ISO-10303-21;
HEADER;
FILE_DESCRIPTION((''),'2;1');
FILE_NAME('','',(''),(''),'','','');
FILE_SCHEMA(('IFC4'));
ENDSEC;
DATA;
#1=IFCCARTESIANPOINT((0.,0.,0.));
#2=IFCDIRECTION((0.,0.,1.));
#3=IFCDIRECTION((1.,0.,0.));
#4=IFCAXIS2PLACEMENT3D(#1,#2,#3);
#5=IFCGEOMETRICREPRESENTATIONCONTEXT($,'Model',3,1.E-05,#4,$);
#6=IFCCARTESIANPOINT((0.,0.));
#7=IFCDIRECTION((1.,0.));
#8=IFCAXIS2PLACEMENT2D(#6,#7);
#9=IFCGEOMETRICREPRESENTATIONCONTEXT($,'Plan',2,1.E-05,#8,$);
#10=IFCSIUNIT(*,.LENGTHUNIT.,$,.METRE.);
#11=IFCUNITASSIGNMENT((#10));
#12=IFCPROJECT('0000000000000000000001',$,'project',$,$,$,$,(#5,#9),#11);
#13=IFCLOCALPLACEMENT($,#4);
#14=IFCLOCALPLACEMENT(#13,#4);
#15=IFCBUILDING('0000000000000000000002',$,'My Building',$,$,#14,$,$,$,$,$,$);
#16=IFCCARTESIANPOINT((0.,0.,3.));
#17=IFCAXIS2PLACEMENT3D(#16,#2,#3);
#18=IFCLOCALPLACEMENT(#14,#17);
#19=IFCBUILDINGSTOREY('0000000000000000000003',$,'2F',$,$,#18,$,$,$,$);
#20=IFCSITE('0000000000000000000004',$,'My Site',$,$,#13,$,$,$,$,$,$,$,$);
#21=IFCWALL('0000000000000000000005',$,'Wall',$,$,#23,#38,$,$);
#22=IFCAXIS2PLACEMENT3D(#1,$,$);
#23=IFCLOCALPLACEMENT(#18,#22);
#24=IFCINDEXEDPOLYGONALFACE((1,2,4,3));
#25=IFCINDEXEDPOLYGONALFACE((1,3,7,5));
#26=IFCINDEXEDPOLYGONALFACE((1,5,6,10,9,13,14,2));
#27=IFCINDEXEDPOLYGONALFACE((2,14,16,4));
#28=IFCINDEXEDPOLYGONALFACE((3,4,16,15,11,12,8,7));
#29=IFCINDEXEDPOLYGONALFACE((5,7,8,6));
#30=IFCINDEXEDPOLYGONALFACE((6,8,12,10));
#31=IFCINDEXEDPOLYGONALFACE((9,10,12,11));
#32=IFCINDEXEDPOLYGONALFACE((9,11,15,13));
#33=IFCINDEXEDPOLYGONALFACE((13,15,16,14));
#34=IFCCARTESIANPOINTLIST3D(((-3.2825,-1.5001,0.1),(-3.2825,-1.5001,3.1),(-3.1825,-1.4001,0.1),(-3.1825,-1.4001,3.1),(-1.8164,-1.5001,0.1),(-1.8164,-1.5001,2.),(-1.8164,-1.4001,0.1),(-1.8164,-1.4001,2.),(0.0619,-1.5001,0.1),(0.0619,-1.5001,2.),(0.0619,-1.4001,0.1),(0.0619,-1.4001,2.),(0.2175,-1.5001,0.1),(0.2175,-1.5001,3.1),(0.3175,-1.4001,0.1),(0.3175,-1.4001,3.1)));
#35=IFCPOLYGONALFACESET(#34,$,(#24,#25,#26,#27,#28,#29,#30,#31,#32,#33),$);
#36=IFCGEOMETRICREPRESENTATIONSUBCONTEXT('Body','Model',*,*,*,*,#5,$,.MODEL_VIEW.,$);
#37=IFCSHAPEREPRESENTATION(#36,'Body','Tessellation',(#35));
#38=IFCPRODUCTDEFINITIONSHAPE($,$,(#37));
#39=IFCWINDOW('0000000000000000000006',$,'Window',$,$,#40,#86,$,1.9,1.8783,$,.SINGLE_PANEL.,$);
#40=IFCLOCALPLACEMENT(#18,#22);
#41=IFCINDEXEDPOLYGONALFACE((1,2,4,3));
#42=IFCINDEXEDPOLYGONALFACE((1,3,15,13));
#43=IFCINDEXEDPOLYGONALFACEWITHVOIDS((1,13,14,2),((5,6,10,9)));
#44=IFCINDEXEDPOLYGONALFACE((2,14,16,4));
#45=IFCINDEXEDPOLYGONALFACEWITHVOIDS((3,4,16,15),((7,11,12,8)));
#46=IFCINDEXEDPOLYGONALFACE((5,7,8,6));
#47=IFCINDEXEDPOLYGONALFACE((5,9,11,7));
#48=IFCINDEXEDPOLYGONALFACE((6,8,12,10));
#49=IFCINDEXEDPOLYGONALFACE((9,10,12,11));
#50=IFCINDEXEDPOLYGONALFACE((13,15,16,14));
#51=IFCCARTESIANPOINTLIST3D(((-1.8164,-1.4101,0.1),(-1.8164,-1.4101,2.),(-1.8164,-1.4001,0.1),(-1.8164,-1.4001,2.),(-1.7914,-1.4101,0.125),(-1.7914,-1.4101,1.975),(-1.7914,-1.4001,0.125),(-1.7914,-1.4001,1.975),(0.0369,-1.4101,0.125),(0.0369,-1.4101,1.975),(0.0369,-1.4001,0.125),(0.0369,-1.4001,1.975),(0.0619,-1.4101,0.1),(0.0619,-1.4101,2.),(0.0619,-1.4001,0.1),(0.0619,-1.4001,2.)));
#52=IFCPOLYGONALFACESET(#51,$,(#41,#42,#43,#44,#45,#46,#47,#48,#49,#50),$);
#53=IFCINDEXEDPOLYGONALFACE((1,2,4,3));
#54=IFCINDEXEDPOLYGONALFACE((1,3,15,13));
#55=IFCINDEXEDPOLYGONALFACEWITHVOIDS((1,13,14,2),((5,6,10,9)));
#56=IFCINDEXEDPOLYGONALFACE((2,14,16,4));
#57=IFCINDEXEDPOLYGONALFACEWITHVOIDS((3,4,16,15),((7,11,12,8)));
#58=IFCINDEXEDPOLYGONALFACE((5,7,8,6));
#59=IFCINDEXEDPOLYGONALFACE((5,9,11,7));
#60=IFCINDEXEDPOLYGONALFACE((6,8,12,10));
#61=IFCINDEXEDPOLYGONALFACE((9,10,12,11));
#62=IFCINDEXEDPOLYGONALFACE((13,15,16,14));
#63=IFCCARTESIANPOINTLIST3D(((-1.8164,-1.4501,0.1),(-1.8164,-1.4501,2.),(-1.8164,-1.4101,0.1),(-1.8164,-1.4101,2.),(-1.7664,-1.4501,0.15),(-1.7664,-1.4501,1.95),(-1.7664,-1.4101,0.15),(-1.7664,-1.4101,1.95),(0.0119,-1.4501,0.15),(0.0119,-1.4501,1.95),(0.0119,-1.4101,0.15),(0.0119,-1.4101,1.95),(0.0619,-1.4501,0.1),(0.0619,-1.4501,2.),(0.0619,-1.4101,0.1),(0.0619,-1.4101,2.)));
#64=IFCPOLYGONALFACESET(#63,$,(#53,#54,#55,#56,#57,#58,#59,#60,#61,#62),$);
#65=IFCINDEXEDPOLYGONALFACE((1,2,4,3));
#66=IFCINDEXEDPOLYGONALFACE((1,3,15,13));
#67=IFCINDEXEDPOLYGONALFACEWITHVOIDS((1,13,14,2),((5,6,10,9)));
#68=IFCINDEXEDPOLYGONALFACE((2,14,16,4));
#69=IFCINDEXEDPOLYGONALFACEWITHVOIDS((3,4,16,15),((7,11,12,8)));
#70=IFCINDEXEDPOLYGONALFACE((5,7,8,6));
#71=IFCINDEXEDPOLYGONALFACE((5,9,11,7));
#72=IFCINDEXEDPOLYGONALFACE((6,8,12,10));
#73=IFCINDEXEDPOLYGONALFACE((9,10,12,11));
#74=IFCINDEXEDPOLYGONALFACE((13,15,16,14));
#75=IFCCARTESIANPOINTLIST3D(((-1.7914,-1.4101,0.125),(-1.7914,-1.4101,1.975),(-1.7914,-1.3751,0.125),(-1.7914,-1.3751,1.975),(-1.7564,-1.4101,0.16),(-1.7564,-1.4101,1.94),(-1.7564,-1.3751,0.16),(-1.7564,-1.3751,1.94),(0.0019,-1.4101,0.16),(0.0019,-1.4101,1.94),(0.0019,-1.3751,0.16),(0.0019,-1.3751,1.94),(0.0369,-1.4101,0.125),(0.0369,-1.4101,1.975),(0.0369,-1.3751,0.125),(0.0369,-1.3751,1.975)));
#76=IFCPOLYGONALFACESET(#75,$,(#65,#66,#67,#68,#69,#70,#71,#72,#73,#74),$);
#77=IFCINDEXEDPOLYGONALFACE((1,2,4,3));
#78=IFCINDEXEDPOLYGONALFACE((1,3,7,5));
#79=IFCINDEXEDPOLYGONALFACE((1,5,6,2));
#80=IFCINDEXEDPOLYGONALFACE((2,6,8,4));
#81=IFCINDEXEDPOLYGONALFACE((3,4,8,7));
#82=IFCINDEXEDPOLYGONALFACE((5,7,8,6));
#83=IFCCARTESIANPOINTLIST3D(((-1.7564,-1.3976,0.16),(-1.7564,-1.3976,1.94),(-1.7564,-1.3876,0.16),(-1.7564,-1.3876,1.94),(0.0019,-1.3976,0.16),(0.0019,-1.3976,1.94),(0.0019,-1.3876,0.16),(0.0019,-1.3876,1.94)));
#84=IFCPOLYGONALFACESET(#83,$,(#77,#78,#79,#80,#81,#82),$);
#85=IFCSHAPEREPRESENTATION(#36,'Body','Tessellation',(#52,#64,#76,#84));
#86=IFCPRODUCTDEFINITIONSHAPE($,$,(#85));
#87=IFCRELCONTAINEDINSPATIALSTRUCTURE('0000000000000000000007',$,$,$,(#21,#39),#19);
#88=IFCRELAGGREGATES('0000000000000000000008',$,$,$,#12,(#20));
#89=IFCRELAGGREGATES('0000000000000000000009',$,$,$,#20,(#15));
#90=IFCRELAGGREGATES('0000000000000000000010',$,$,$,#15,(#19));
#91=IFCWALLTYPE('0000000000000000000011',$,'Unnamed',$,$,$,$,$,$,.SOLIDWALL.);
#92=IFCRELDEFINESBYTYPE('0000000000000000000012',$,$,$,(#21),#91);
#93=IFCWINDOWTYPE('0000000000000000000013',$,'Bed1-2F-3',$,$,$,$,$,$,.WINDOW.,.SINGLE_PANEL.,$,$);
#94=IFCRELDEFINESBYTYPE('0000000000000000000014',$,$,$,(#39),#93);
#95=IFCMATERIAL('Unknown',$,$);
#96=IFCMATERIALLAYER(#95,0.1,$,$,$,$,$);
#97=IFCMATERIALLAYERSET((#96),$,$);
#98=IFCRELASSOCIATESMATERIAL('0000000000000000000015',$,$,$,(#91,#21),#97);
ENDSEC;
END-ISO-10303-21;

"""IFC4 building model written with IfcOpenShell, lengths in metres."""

from ifc_helpers import new_model, entity, si_unit, frame, origin_with_axes, origin_2d_with_axis, place, context, subcontext, project, spatial, line, indexed_curve, outline, extrude, shape, source, transform, mapped, material, layer, layer_set, layer_usage, type_object, type_shapes, element, fill, save


model = new_model("IFC4")

# Units and contexts
model_context = context("Model", 3, precision=1e-05, world=origin_with_axes())
plan_context = context("Plan", 2, precision=1e-05, world=origin_2d_with_axis())
body_context_1 = subcontext(model_context, "Body", "Model", "MODEL_VIEW")
body_context_2 = subcontext(plan_context, "Body", "Plan", "PLAN_VIEW")
ifc_project = project(units=[si_unit("LENGTHUNIT", "METRE")], contexts=[model_context, plan_context])

# Site, building, storey
site_placement = place(None, origin_with_axes())
site = spatial("IfcSite", under=ifc_project, at=site_placement, Name="My Site")
building_placement = place(site_placement, origin_with_axes())
building = spatial("IfcBuilding", under=site, at=building_placement, Name="My Building")
storey_placement = place(building_placement, frame((0.0, 0.0, 3.0), z_axis=(0.0, 0.0, 1.0), x_axis=(1.0, 0.0, 0.0)))
storey = spatial("IfcBuildingStorey", under=building, at=storey_placement, Name="2F")

# Shared definitions
ifc_material = material(Name="Unknown")
ifc_layer = layer(ifc_material, 0.1)
ifc_layer_set = layer_set([ifc_layer])
wall_type = type_object("IfcWallType", Name="Unnamed", PredefinedType="SOLIDWALL", material=ifc_layer_set)

# Wall, opening, window
ifc_layer_usage_1 = layer_usage(ifc_layer_set, "AXIS2", "POSITIVE", 0.0)
wall_1_placement = place(storey_placement, frame((-3.1825, -1.5001, 0.1), z_axis=(0.0, 0.0, 1.0), x_axis=(1.0, 0.0, 0.0)))
wall_1 = element("IfcWall", 1, at=wall_1_placement, inside=storey, type_object=wall_type, material=ifc_layer_usage_1, Name="Wall", context=body_context_1, shape_type="SweptSolid", body=[
    extrude(outline(indexed_curve([(-0.1, 0.0), (0.0, 0.1), (3.5, 0.1), (3.4, 0.0)], segments=[line(1, 2, 3, 4, 1)])), origin_with_axes(), (0.0, 0.0, 1.0), 3.0),
])
shared_shape_1 = source(origin_with_axes(), body_context_1, "Body", "SweptSolid", [
    extrude(outline(indexed_curve([(0.0, 0.0), (1.8783, 0.0), (1.8783, 1.9), (0.0, 1.9)], segments=[line(1, 2, 3, 4, 1)])), frame((0.0, -0.6, 0.0), z_axis=(0.0, -1.0, 0.0), x_axis=(1.0, 0.0, 0.0)), (0.0, 0.0, -1.0), 1.2),
])
opening_1_placement = place(wall_1_placement, frame((1.3661, 0.0, 0.0), z_axis=(0.0, 0.0, 1.0), x_axis=(1.0, 0.0, 0.0)))
opening_1 = element("IfcOpeningElement", 2, at=opening_1_placement, cuts=wall_1, PredefinedType="OPENING", context=body_context_1, shape_type="MappedRepresentation", body=[
    mapped(shared_shape_1, transform((0.0, 0.0, 0.0), x_axis=(1.0, 0.0, 0.0), y_axis=(0.0, 1.0, 0.0), z_axis=(0.0, 0.0, 1.0), scale=1.0)),
])
window_type_1 = type_object("IfcWindowType", Name="Bed1-2F-3", PartitioningType="SINGLE_PANEL", PredefinedType="WINDOW")
shared_shape_2 = source(origin_with_axes(), body_context_1, "Body", "SweptSolid", [
    extrude(outline(indexed_curve([(0.0, 0.0), (1.8783, 0.0), (1.8783, 1.9), (0.0, 1.9)], segments=[line(1, 2, 3, 4, 1)]), holes=[indexed_curve([(0.025, 0.025), (1.8533, 0.025), (1.8533, 1.875), (0.025, 1.875)], segments=[line(1, 2, 3, 4, 1)])]), frame((0.0, 0.09, 0.0), z_axis=(0.0, -1.0, 0.0), x_axis=(1.0, 0.0, 0.0)), (0.0, 0.0, -1.0), 0.01),
    extrude(outline(indexed_curve([(0.0, 0.0), (1.8783, 0.0), (1.8783, 1.9), (0.0, 1.9)], segments=[line(1, 2, 3, 4, 1)]), holes=[indexed_curve([(0.05, 0.05), (1.8283, 0.05), (1.8283, 1.85), (0.05, 1.85)], segments=[line(1, 2, 3, 4, 1)])]), frame((0.0, 0.05, 0.0), z_axis=(0.0, -1.0, 0.0), x_axis=(1.0, 0.0, 0.0)), (0.0, 0.0, -1.0), 0.04),
    extrude(outline(indexed_curve([(0.0, 0.0), (1.8283, 0.0), (1.8283, 1.85), (0.0, 1.85)], segments=[line(1, 2, 3, 4, 1)]), holes=[indexed_curve([(0.035, 0.035), (1.7933, 0.035), (1.7933, 1.815), (0.035, 1.815)], segments=[line(1, 2, 3, 4, 1)])]), frame((0.025, 0.09, 0.025), z_axis=(0.0, -1.0, 0.0), x_axis=(1.0, 0.0, 0.0)), (0.0, 0.0, -1.0), 0.035),
    extrude(outline(indexed_curve([(0.035, 0.035), (1.7933, 0.035), (1.7933, 1.815), (0.035, 1.815)], segments=[line(1, 2, 3, 4, 1)])), frame((0.025, 0.1025, 0.025), z_axis=(0.0, -1.0, 0.0), x_axis=(1.0, 0.0, 0.0)), (0.0, 0.0, -1.0), 0.01),
])
shared_shape_3 = source(origin_with_axes(), body_context_2, "Body", "Curve2D", [
    entity("IfcIndexedPolyCurve", entity("IfcCartesianPointList2D", [[0.05, 0.05], [1.8283, 0.05]])),
    entity("IfcIndexedPolyCurve", entity("IfcCartesianPointList2D", [[0.0, 0.1], [0.025, 0.1], [0.025, 0.09], [0.05, 0.09], [0.05, 0.05], [0.0, 0.05]]), [entity("IfcLineIndex", [1, 2, 3, 4, 5, 6, 1])]),
    entity("IfcIndexedPolyCurve", entity("IfcCartesianPointList2D", [[1.8783, 0.1], [1.8533, 0.1], [1.8533, 0.09], [1.8283, 0.09], [1.8283, 0.05], [1.8783, 0.05]]), [entity("IfcLineIndex", [1, 2, 3, 4, 5, 6, 1])]),
    entity("IfcIndexedPolyCurve", entity("IfcCartesianPointList2D", [[0.025, 0.09], [0.06, 0.09], [0.06, 0.125], [0.025, 0.125]]), [entity("IfcLineIndex", [1, 2, 3, 4, 1])]),
    entity("IfcIndexedPolyCurve", entity("IfcCartesianPointList2D", [[1.8533, 0.09], [1.8183, 0.09], [1.8183, 0.125], [1.8533, 0.125]]), [entity("IfcLineIndex", [1, 2, 3, 4, 1])]),
    entity("IfcIndexedPolyCurve", entity("IfcCartesianPointList2D", [[0.06, 0.09], [1.8183, 0.09]])),
    entity("IfcIndexedPolyCurve", entity("IfcCartesianPointList2D", [[0.06, 0.125], [1.8183, 0.125]])),
    entity("IfcIndexedPolyCurve", entity("IfcCartesianPointList2D", [[0.06, 0.1075], [1.8183, 0.1075]])),
])
type_shapes(window_type_1, [shared_shape_2, shared_shape_3])
window_1_placement = place(opening_1_placement, frame((0.0, 0.0, 0.0), z_axis=(0.0, 0.0, 1.0), x_axis=(1.0, 0.0, 0.0)))
window_1 = element("IfcWindow", 3, at=window_1_placement, inside=storey, type_object=window_type_1, Name="Window", OverallHeight=1.9, OverallWidth=1.8783, PartitioningType="SINGLE_PANEL", shapes=[
    shape(body_context_1, "Body", "MappedRepresentation", [mapped(shared_shape_2, transform((0.0, 0.0, 0.0), x_axis=(1.0, 0.0, 0.0), y_axis=(0.0, 1.0, 0.0), z_axis=(0.0, 0.0, 1.0), scale=1.0))]),
    shape(body_context_2, "Body", "MappedRepresentation", [mapped(shared_shape_3, transform((0.0, 0.0, 0.0), x_axis=(1.0, 0.0, 0.0), y_axis=(0.0, 1.0, 0.0), z_axis=(0.0, 0.0, 1.0), scale=1.0))]),
])
fill(opening_1, window_1)

save(model, "model.ifc")
